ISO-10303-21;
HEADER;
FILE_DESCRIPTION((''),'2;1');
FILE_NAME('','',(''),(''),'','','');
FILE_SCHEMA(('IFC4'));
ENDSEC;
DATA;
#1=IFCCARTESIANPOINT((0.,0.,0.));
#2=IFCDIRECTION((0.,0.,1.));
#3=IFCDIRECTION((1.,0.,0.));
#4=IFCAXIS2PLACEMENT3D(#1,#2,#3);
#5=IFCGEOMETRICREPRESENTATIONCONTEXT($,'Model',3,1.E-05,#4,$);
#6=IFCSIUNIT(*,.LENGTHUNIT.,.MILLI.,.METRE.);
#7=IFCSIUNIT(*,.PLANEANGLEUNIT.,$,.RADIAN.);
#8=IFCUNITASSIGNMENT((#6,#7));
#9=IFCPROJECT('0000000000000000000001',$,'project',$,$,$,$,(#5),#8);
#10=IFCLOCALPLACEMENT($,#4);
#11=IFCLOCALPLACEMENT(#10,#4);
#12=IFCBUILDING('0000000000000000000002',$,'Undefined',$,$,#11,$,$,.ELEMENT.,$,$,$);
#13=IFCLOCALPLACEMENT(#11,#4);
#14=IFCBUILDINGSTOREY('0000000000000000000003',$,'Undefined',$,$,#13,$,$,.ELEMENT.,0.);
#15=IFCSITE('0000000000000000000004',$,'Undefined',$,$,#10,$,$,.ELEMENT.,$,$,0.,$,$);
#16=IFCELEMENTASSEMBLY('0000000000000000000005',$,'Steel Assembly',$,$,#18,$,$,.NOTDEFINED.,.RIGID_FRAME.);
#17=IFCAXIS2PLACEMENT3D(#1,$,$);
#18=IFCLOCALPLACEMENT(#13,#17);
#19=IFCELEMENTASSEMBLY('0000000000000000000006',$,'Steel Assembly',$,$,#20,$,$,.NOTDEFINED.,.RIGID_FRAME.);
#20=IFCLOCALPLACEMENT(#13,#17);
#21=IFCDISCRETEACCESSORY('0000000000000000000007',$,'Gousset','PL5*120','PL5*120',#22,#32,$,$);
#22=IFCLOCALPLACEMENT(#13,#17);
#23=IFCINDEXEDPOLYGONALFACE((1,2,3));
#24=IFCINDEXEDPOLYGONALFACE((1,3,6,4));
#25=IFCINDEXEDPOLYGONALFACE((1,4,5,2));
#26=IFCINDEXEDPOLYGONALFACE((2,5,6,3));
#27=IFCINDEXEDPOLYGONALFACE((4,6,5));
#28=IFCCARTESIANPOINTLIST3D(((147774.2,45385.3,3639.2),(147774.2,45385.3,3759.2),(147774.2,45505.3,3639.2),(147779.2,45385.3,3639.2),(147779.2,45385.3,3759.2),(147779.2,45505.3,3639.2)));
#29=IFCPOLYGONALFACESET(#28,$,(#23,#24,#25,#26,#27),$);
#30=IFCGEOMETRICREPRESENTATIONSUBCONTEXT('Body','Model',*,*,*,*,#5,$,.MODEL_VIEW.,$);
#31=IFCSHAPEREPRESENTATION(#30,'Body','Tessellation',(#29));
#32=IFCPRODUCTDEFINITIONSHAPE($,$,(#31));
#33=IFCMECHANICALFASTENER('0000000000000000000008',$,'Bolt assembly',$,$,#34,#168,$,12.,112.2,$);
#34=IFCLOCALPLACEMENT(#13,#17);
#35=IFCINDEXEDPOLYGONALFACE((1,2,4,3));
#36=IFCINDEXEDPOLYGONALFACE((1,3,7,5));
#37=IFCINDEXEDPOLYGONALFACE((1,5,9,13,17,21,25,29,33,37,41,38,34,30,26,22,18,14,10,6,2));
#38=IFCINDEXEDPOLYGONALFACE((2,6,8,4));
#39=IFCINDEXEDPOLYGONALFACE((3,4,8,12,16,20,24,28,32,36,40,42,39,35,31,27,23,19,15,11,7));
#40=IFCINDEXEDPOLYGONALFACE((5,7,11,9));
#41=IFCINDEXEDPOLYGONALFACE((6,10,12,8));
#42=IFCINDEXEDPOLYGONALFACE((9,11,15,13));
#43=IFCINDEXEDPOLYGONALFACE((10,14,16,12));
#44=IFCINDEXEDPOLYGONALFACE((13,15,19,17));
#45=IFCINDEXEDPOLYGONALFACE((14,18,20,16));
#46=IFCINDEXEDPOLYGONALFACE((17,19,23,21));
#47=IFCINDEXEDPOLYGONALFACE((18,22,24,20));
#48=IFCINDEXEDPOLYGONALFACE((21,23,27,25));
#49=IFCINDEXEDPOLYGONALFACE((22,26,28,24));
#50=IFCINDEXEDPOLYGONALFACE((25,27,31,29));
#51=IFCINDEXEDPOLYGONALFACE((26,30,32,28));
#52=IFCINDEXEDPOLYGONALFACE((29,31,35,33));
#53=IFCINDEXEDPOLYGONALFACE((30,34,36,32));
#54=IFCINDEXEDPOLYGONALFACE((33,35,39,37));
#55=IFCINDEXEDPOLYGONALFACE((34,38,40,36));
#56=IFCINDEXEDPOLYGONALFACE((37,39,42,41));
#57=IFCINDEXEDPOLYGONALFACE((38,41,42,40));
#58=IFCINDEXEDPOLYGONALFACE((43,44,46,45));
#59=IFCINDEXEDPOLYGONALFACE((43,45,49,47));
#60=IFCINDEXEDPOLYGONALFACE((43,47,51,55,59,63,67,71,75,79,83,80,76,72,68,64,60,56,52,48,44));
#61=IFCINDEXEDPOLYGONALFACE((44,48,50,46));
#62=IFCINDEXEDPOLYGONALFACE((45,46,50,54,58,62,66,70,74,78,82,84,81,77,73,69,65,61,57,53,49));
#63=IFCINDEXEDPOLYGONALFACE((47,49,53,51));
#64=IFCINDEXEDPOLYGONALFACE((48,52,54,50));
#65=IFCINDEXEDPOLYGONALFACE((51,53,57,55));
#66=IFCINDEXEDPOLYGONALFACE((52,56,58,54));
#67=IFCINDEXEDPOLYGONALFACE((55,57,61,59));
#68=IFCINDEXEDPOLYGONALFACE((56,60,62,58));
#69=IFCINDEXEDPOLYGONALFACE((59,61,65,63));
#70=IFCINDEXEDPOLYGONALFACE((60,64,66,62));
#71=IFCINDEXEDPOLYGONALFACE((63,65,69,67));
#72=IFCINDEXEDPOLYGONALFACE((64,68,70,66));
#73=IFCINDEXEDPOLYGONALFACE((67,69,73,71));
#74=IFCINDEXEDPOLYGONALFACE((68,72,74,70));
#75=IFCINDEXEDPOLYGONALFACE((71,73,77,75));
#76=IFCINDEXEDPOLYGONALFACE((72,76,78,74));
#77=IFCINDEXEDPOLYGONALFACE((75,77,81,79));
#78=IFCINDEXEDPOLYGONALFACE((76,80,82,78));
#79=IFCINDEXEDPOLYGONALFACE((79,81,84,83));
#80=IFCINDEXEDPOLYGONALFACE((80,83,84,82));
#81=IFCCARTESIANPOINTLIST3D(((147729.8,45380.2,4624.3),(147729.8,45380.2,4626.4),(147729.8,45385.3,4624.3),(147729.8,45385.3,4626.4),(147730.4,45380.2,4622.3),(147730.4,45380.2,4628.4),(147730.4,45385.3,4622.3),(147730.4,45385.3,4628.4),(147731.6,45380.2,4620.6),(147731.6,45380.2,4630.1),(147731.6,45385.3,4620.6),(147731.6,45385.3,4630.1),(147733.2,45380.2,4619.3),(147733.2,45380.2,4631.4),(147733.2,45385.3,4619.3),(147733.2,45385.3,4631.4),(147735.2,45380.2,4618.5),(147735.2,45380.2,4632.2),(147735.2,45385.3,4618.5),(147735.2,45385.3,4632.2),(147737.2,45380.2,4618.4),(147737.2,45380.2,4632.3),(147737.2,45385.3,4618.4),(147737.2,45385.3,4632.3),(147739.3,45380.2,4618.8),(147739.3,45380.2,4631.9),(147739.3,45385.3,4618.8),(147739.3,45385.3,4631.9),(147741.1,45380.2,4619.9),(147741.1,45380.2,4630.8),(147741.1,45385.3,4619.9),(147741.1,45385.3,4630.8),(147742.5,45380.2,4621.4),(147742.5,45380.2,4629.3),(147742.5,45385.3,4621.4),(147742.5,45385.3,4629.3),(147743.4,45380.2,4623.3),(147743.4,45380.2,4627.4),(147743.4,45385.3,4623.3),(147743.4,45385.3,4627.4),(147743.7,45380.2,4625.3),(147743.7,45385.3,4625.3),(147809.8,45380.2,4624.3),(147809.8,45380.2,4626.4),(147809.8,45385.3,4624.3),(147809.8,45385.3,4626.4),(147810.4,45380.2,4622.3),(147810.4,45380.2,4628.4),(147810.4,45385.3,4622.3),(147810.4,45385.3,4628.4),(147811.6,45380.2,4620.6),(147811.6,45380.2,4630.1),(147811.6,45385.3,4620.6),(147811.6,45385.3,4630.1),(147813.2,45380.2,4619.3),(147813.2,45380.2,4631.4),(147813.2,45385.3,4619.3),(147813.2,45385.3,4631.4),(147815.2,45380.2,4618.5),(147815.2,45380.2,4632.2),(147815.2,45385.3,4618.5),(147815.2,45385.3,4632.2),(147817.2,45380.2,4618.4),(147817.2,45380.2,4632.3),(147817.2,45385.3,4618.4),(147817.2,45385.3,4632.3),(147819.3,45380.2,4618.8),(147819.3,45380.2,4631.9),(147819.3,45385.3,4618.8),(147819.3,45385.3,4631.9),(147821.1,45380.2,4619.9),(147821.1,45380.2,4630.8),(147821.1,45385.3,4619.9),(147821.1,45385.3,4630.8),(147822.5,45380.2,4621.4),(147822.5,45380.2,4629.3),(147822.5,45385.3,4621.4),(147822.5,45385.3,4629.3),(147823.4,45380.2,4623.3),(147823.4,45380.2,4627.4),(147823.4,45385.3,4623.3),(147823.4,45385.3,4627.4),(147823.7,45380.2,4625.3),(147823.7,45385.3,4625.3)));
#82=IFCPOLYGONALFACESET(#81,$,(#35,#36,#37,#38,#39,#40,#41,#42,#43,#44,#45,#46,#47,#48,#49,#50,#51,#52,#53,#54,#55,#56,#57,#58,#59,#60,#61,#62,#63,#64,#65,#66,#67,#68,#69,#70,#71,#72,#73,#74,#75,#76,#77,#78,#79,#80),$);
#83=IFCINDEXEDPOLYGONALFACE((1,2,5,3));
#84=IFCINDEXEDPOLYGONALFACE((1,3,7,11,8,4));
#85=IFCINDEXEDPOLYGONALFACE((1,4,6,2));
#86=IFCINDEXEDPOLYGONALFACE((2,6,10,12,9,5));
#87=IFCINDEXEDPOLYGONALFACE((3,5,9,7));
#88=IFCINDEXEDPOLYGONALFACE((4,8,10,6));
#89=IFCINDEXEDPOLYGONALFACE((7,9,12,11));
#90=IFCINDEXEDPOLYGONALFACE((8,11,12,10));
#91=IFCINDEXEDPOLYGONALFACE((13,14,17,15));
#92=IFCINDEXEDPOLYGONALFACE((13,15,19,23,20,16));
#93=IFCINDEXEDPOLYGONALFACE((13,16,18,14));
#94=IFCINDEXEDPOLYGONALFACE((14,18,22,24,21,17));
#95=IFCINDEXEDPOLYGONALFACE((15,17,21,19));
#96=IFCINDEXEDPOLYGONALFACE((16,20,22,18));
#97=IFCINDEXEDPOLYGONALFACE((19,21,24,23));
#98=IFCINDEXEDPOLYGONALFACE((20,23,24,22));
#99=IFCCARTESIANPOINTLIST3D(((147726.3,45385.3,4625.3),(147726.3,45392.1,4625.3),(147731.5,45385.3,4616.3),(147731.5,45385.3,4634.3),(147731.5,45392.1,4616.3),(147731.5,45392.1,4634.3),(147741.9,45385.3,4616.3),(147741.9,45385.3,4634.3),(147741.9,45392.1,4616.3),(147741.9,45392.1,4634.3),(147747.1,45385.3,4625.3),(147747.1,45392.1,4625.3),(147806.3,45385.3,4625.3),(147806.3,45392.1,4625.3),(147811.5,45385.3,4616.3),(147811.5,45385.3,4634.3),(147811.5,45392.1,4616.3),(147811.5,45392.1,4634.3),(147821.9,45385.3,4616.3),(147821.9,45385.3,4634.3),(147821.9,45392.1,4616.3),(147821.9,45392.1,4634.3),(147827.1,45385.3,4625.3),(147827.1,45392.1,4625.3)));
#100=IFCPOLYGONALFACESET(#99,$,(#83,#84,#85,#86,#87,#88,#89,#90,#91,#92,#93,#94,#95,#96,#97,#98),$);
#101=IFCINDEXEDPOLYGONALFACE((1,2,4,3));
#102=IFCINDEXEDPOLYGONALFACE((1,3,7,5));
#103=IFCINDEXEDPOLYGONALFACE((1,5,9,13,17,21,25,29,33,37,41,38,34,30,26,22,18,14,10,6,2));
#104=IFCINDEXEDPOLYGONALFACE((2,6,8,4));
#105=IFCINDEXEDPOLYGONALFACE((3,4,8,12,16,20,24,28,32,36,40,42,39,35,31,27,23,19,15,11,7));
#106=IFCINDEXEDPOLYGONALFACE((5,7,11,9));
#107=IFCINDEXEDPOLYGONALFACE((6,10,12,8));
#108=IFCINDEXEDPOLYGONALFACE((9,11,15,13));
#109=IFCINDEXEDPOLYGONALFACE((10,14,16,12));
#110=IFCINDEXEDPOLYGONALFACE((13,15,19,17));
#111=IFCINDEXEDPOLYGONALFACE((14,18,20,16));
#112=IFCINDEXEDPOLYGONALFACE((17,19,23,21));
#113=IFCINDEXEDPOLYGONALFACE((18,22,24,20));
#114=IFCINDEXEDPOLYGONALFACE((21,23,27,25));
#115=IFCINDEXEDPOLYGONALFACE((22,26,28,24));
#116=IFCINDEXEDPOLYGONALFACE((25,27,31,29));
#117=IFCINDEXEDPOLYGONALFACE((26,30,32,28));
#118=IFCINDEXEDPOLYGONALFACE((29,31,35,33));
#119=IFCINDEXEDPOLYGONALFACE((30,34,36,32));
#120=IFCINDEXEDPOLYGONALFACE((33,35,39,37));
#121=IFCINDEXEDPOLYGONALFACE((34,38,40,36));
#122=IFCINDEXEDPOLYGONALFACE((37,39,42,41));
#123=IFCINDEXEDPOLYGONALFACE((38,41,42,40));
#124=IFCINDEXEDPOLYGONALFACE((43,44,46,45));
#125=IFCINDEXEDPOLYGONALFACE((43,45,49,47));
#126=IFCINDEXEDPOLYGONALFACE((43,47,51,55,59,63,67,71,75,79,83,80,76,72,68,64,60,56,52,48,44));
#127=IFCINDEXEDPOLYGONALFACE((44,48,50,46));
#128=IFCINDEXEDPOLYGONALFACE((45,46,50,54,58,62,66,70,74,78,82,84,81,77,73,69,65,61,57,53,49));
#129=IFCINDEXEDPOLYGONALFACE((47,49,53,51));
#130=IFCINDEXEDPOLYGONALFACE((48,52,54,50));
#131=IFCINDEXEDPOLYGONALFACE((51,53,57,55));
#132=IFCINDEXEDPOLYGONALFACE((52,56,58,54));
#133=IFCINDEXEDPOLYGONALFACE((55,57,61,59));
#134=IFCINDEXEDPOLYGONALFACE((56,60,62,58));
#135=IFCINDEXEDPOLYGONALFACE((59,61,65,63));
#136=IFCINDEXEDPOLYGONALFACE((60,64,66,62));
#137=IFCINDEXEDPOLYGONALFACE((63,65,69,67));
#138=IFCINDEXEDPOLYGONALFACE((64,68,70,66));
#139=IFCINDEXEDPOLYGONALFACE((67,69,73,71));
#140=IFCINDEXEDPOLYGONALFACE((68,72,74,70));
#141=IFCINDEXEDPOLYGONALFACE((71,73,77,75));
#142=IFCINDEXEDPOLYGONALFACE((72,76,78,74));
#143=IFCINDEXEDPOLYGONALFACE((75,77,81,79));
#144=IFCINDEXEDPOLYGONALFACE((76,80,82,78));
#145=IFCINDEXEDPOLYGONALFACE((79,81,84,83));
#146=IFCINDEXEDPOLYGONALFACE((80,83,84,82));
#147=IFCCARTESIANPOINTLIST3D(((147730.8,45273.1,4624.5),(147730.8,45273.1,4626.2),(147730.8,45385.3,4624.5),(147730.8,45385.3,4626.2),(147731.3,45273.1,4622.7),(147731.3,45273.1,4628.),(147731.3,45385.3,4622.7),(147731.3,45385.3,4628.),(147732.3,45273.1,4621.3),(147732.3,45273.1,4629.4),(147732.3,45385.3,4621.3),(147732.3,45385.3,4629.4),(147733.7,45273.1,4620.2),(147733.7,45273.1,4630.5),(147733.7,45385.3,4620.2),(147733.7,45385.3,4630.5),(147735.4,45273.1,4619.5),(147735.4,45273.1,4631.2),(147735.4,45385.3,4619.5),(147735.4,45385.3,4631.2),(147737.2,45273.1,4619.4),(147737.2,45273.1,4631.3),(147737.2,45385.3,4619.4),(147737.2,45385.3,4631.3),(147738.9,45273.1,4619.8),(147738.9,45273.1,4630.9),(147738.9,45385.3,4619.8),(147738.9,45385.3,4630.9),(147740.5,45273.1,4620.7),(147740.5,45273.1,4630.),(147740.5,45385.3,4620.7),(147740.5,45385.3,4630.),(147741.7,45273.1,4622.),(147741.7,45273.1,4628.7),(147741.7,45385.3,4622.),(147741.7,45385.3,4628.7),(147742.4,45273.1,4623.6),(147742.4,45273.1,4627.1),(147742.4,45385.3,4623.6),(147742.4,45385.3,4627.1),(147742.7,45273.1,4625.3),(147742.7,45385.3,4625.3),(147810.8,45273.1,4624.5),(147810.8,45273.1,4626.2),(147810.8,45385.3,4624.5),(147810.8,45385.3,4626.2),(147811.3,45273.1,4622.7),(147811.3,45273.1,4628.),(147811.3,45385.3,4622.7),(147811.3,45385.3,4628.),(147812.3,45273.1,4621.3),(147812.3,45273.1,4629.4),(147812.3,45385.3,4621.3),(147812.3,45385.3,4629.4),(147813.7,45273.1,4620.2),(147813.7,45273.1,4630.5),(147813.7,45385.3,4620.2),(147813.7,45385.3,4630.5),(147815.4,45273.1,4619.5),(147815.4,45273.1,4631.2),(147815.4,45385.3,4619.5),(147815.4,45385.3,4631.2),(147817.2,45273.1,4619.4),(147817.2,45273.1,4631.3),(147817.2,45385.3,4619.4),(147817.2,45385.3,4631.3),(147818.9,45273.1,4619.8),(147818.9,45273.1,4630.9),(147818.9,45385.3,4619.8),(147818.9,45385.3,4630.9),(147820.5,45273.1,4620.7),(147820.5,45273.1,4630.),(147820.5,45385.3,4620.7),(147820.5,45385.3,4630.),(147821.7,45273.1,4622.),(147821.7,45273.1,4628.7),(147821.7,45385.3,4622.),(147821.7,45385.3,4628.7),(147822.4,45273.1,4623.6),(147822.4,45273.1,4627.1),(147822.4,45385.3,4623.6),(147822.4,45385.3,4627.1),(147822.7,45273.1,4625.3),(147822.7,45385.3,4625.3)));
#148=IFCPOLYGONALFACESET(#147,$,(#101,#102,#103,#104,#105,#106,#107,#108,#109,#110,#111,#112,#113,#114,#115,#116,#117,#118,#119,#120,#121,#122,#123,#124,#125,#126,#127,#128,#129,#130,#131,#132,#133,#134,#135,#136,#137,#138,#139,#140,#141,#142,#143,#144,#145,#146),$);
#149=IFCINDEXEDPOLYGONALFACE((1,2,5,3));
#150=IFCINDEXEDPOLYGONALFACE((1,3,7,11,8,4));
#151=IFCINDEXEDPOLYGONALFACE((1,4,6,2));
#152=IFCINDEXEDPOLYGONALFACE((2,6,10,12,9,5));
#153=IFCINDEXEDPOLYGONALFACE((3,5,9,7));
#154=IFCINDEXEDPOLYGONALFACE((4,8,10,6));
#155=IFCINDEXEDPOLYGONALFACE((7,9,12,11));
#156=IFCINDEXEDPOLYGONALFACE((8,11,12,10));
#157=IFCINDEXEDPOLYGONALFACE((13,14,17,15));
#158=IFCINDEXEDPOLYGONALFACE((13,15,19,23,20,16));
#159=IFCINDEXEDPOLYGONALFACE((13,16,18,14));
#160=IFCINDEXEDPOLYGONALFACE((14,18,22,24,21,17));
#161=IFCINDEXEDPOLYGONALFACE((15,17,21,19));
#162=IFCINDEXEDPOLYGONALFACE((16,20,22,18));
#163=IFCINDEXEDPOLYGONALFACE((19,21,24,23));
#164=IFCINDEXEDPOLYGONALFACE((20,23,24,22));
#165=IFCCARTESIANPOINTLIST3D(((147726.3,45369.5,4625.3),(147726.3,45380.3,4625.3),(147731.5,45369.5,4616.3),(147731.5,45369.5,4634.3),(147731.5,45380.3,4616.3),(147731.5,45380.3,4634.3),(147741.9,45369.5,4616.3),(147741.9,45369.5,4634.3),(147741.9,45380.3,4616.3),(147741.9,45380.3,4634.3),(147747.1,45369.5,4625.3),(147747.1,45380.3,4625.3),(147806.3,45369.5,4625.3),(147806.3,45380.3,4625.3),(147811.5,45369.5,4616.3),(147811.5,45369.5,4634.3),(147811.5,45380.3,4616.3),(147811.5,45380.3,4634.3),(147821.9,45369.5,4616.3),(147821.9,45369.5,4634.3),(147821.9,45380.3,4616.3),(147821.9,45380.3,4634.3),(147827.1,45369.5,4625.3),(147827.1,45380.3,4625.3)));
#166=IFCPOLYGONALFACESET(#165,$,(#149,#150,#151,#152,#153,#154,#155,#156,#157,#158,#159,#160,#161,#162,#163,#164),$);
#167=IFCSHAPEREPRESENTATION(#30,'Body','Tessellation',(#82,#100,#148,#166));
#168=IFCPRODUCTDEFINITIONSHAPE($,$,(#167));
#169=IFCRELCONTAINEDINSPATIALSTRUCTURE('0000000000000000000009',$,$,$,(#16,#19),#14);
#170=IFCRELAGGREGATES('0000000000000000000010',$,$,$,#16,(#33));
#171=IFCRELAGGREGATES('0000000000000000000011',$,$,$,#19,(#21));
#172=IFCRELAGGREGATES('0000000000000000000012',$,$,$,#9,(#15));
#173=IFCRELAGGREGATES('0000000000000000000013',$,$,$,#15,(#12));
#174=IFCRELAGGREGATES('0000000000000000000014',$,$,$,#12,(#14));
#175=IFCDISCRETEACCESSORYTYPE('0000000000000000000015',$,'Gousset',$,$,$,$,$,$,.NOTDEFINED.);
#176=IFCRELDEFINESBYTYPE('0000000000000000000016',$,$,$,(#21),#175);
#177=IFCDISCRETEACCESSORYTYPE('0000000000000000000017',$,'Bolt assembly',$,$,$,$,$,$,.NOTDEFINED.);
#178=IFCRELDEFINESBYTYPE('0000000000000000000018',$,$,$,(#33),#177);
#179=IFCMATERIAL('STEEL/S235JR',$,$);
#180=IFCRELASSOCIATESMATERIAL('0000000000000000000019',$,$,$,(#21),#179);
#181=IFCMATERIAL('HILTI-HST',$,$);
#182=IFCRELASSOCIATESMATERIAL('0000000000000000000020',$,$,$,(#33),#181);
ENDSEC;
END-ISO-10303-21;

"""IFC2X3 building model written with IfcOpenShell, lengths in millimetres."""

from ifc_helpers import new_model, si_unit, frame, origin_with_axes, origin_2d_with_axis, place, context, subcontext, project, spatial, polyline, circle, outline, extrude, source, transform, mapped, material, type_object, element, aggregate, save


model = new_model("IFC2X3")

# Units and contexts
model_context = context("Model", 3, precision=1e-05, world=origin_with_axes())
body_context = subcontext(model_context, "Body", "Model", "MODEL_VIEW")
ifc_project = project(units=[si_unit("LENGTHUNIT", "METRE", prefix="MILLI"), si_unit("PLANEANGLEUNIT", "RADIAN")], contexts=[model_context])

# Site, building, storey
site_placement = place(None, origin_with_axes())
site = spatial("IfcSite", under=ifc_project, at=site_placement, Name="Undefined", CompositionType="ELEMENT", RefElevation=0.0)
building_placement = place(site_placement, origin_with_axes())
building = spatial("IfcBuilding", under=site, at=building_placement, Name="Undefined", CompositionType="ELEMENT")
storey_placement = place(building_placement, origin_with_axes())
storey = spatial("IfcBuildingStorey", under=building, at=storey_placement, Name="Undefined", CompositionType="ELEMENT", Elevation=0.0)

# Shared definitions
ifc_material_1 = material(Name="STEEL/S235JR")

# Element assemblies
assembly_1_placement = place(storey_placement, origin_with_axes())
assembly_1 = element("IfcElementAssembly", 1, at=assembly_1_placement, inside=storey, Name="Steel Assembly", AssemblyPlace="NOTDEFINED", PredefinedType="RIGID_FRAME")
assembly_2_placement = place(storey_placement, origin_with_axes())
assembly_2 = element("IfcElementAssembly", 2, at=assembly_2_placement, inside=storey, Name="Steel Assembly", AssemblyPlace="NOTDEFINED", PredefinedType="RIGID_FRAME")

# Discrete accessory
discrete_accessory_type_1 = type_object("IfcDiscreteAccessoryType", Name="Gousset")
discrete_accessory_1_placement = place(assembly_2_placement, frame((147776.7, 45505.3, 3639.2), z_axis=(-1.0, 0.0, 0.0), x_axis=(0.0, -1.0, 0.0)))
discrete_accessory_1 = element("IfcDiscreteAccessory", 3, at=discrete_accessory_1_placement, type_object=discrete_accessory_type_1, material=ifc_material_1, Name="Gousset", Description="PL5*120", ObjectType="PL5*120", context=body_context, shape_type="SweptSolid", body=[
    extrude(outline(polyline([(0.0, 0.0), (120.0, 0.0), (120.0, 120.0), (0.0, 0.0)])), frame((0.0, 0.0, -2.5), z_axis=(0.0, 0.0, 1.0), x_axis=(1.0, 0.0, 0.0)), (0.0, 0.0, 1.0), 5.0),
])

# Mechanical fastener
ifc_material_2 = material(Name="HILTI-HST")
discrete_accessory_type_2 = type_object("IfcDiscreteAccessoryType", Name="Bolt assembly")
shared_shape_1 = source(origin_with_axes(), body_context, "Body", "SweptSolid", [
    extrude(circle(Radius=7.0, at=origin_2d_with_axis()), frame((0.0, 0.0, 0.0), z_axis=(0.0, 1.0, 0.0), x_axis=(1.0, 0.0, 0.0)), (0.0, 0.0, 1.0), 5.1),
    extrude(outline(polyline([(10.4, 0.0), (5.2, 9.0), (-5.2, 9.0), (-10.4, 0.0), (-5.2, -9.0), (5.2, -9.0), (10.4, 0.0)])), frame((0.0, -6.8, 0.0), z_axis=(0.0, 1.0, 0.0), x_axis=(1.0, 0.0, 0.0)), (0.0, 0.0, 1.0), 6.8),
    extrude(circle(Radius=6.0, at=origin_2d_with_axis()), frame((0.0, 0.0, 0.0), z_axis=(0.0, 1.0, 0.0), x_axis=(1.0, 0.0, 0.0)), (0.0, 0.0, 1.0), 112.2),
    extrude(outline(polyline([(10.4, 0.0), (5.2, 9.0), (-5.2, 9.0), (-10.4, 0.0), (-5.2, -9.0), (5.2, -9.0), (10.4, 0.0)])), frame((0.0, 5.0, 0.0), z_axis=(0.0, 1.0, 0.0), x_axis=(1.0, 0.0, 0.0)), (0.0, 0.0, 1.0), 10.8),
])
mechanical_fastener_1_placement = place(assembly_1_placement, frame((147736.7, 45385.3, 4625.3), z_axis=(0.0, 0.0, -1.0), x_axis=(1.0, 0.0, 0.0)))
mechanical_fastener_1 = element("IfcMechanicalFastener", 4, at=mechanical_fastener_1_placement, type_object=discrete_accessory_type_2, material=ifc_material_2, Name="Bolt assembly", NominalDiameter=12.0, NominalLength=112.2, context=body_context, shape_type="MappedRepresentation", body=[
    mapped(shared_shape_1, transform((0.0, 0.0, 0.0))),
    mapped(shared_shape_1, transform((80.0, 0.0, 0.0))),
])
aggregate(assembly_1, [mechanical_fastener_1])
aggregate(assembly_2, [discrete_accessory_1])

save(model, "model.ifc")
